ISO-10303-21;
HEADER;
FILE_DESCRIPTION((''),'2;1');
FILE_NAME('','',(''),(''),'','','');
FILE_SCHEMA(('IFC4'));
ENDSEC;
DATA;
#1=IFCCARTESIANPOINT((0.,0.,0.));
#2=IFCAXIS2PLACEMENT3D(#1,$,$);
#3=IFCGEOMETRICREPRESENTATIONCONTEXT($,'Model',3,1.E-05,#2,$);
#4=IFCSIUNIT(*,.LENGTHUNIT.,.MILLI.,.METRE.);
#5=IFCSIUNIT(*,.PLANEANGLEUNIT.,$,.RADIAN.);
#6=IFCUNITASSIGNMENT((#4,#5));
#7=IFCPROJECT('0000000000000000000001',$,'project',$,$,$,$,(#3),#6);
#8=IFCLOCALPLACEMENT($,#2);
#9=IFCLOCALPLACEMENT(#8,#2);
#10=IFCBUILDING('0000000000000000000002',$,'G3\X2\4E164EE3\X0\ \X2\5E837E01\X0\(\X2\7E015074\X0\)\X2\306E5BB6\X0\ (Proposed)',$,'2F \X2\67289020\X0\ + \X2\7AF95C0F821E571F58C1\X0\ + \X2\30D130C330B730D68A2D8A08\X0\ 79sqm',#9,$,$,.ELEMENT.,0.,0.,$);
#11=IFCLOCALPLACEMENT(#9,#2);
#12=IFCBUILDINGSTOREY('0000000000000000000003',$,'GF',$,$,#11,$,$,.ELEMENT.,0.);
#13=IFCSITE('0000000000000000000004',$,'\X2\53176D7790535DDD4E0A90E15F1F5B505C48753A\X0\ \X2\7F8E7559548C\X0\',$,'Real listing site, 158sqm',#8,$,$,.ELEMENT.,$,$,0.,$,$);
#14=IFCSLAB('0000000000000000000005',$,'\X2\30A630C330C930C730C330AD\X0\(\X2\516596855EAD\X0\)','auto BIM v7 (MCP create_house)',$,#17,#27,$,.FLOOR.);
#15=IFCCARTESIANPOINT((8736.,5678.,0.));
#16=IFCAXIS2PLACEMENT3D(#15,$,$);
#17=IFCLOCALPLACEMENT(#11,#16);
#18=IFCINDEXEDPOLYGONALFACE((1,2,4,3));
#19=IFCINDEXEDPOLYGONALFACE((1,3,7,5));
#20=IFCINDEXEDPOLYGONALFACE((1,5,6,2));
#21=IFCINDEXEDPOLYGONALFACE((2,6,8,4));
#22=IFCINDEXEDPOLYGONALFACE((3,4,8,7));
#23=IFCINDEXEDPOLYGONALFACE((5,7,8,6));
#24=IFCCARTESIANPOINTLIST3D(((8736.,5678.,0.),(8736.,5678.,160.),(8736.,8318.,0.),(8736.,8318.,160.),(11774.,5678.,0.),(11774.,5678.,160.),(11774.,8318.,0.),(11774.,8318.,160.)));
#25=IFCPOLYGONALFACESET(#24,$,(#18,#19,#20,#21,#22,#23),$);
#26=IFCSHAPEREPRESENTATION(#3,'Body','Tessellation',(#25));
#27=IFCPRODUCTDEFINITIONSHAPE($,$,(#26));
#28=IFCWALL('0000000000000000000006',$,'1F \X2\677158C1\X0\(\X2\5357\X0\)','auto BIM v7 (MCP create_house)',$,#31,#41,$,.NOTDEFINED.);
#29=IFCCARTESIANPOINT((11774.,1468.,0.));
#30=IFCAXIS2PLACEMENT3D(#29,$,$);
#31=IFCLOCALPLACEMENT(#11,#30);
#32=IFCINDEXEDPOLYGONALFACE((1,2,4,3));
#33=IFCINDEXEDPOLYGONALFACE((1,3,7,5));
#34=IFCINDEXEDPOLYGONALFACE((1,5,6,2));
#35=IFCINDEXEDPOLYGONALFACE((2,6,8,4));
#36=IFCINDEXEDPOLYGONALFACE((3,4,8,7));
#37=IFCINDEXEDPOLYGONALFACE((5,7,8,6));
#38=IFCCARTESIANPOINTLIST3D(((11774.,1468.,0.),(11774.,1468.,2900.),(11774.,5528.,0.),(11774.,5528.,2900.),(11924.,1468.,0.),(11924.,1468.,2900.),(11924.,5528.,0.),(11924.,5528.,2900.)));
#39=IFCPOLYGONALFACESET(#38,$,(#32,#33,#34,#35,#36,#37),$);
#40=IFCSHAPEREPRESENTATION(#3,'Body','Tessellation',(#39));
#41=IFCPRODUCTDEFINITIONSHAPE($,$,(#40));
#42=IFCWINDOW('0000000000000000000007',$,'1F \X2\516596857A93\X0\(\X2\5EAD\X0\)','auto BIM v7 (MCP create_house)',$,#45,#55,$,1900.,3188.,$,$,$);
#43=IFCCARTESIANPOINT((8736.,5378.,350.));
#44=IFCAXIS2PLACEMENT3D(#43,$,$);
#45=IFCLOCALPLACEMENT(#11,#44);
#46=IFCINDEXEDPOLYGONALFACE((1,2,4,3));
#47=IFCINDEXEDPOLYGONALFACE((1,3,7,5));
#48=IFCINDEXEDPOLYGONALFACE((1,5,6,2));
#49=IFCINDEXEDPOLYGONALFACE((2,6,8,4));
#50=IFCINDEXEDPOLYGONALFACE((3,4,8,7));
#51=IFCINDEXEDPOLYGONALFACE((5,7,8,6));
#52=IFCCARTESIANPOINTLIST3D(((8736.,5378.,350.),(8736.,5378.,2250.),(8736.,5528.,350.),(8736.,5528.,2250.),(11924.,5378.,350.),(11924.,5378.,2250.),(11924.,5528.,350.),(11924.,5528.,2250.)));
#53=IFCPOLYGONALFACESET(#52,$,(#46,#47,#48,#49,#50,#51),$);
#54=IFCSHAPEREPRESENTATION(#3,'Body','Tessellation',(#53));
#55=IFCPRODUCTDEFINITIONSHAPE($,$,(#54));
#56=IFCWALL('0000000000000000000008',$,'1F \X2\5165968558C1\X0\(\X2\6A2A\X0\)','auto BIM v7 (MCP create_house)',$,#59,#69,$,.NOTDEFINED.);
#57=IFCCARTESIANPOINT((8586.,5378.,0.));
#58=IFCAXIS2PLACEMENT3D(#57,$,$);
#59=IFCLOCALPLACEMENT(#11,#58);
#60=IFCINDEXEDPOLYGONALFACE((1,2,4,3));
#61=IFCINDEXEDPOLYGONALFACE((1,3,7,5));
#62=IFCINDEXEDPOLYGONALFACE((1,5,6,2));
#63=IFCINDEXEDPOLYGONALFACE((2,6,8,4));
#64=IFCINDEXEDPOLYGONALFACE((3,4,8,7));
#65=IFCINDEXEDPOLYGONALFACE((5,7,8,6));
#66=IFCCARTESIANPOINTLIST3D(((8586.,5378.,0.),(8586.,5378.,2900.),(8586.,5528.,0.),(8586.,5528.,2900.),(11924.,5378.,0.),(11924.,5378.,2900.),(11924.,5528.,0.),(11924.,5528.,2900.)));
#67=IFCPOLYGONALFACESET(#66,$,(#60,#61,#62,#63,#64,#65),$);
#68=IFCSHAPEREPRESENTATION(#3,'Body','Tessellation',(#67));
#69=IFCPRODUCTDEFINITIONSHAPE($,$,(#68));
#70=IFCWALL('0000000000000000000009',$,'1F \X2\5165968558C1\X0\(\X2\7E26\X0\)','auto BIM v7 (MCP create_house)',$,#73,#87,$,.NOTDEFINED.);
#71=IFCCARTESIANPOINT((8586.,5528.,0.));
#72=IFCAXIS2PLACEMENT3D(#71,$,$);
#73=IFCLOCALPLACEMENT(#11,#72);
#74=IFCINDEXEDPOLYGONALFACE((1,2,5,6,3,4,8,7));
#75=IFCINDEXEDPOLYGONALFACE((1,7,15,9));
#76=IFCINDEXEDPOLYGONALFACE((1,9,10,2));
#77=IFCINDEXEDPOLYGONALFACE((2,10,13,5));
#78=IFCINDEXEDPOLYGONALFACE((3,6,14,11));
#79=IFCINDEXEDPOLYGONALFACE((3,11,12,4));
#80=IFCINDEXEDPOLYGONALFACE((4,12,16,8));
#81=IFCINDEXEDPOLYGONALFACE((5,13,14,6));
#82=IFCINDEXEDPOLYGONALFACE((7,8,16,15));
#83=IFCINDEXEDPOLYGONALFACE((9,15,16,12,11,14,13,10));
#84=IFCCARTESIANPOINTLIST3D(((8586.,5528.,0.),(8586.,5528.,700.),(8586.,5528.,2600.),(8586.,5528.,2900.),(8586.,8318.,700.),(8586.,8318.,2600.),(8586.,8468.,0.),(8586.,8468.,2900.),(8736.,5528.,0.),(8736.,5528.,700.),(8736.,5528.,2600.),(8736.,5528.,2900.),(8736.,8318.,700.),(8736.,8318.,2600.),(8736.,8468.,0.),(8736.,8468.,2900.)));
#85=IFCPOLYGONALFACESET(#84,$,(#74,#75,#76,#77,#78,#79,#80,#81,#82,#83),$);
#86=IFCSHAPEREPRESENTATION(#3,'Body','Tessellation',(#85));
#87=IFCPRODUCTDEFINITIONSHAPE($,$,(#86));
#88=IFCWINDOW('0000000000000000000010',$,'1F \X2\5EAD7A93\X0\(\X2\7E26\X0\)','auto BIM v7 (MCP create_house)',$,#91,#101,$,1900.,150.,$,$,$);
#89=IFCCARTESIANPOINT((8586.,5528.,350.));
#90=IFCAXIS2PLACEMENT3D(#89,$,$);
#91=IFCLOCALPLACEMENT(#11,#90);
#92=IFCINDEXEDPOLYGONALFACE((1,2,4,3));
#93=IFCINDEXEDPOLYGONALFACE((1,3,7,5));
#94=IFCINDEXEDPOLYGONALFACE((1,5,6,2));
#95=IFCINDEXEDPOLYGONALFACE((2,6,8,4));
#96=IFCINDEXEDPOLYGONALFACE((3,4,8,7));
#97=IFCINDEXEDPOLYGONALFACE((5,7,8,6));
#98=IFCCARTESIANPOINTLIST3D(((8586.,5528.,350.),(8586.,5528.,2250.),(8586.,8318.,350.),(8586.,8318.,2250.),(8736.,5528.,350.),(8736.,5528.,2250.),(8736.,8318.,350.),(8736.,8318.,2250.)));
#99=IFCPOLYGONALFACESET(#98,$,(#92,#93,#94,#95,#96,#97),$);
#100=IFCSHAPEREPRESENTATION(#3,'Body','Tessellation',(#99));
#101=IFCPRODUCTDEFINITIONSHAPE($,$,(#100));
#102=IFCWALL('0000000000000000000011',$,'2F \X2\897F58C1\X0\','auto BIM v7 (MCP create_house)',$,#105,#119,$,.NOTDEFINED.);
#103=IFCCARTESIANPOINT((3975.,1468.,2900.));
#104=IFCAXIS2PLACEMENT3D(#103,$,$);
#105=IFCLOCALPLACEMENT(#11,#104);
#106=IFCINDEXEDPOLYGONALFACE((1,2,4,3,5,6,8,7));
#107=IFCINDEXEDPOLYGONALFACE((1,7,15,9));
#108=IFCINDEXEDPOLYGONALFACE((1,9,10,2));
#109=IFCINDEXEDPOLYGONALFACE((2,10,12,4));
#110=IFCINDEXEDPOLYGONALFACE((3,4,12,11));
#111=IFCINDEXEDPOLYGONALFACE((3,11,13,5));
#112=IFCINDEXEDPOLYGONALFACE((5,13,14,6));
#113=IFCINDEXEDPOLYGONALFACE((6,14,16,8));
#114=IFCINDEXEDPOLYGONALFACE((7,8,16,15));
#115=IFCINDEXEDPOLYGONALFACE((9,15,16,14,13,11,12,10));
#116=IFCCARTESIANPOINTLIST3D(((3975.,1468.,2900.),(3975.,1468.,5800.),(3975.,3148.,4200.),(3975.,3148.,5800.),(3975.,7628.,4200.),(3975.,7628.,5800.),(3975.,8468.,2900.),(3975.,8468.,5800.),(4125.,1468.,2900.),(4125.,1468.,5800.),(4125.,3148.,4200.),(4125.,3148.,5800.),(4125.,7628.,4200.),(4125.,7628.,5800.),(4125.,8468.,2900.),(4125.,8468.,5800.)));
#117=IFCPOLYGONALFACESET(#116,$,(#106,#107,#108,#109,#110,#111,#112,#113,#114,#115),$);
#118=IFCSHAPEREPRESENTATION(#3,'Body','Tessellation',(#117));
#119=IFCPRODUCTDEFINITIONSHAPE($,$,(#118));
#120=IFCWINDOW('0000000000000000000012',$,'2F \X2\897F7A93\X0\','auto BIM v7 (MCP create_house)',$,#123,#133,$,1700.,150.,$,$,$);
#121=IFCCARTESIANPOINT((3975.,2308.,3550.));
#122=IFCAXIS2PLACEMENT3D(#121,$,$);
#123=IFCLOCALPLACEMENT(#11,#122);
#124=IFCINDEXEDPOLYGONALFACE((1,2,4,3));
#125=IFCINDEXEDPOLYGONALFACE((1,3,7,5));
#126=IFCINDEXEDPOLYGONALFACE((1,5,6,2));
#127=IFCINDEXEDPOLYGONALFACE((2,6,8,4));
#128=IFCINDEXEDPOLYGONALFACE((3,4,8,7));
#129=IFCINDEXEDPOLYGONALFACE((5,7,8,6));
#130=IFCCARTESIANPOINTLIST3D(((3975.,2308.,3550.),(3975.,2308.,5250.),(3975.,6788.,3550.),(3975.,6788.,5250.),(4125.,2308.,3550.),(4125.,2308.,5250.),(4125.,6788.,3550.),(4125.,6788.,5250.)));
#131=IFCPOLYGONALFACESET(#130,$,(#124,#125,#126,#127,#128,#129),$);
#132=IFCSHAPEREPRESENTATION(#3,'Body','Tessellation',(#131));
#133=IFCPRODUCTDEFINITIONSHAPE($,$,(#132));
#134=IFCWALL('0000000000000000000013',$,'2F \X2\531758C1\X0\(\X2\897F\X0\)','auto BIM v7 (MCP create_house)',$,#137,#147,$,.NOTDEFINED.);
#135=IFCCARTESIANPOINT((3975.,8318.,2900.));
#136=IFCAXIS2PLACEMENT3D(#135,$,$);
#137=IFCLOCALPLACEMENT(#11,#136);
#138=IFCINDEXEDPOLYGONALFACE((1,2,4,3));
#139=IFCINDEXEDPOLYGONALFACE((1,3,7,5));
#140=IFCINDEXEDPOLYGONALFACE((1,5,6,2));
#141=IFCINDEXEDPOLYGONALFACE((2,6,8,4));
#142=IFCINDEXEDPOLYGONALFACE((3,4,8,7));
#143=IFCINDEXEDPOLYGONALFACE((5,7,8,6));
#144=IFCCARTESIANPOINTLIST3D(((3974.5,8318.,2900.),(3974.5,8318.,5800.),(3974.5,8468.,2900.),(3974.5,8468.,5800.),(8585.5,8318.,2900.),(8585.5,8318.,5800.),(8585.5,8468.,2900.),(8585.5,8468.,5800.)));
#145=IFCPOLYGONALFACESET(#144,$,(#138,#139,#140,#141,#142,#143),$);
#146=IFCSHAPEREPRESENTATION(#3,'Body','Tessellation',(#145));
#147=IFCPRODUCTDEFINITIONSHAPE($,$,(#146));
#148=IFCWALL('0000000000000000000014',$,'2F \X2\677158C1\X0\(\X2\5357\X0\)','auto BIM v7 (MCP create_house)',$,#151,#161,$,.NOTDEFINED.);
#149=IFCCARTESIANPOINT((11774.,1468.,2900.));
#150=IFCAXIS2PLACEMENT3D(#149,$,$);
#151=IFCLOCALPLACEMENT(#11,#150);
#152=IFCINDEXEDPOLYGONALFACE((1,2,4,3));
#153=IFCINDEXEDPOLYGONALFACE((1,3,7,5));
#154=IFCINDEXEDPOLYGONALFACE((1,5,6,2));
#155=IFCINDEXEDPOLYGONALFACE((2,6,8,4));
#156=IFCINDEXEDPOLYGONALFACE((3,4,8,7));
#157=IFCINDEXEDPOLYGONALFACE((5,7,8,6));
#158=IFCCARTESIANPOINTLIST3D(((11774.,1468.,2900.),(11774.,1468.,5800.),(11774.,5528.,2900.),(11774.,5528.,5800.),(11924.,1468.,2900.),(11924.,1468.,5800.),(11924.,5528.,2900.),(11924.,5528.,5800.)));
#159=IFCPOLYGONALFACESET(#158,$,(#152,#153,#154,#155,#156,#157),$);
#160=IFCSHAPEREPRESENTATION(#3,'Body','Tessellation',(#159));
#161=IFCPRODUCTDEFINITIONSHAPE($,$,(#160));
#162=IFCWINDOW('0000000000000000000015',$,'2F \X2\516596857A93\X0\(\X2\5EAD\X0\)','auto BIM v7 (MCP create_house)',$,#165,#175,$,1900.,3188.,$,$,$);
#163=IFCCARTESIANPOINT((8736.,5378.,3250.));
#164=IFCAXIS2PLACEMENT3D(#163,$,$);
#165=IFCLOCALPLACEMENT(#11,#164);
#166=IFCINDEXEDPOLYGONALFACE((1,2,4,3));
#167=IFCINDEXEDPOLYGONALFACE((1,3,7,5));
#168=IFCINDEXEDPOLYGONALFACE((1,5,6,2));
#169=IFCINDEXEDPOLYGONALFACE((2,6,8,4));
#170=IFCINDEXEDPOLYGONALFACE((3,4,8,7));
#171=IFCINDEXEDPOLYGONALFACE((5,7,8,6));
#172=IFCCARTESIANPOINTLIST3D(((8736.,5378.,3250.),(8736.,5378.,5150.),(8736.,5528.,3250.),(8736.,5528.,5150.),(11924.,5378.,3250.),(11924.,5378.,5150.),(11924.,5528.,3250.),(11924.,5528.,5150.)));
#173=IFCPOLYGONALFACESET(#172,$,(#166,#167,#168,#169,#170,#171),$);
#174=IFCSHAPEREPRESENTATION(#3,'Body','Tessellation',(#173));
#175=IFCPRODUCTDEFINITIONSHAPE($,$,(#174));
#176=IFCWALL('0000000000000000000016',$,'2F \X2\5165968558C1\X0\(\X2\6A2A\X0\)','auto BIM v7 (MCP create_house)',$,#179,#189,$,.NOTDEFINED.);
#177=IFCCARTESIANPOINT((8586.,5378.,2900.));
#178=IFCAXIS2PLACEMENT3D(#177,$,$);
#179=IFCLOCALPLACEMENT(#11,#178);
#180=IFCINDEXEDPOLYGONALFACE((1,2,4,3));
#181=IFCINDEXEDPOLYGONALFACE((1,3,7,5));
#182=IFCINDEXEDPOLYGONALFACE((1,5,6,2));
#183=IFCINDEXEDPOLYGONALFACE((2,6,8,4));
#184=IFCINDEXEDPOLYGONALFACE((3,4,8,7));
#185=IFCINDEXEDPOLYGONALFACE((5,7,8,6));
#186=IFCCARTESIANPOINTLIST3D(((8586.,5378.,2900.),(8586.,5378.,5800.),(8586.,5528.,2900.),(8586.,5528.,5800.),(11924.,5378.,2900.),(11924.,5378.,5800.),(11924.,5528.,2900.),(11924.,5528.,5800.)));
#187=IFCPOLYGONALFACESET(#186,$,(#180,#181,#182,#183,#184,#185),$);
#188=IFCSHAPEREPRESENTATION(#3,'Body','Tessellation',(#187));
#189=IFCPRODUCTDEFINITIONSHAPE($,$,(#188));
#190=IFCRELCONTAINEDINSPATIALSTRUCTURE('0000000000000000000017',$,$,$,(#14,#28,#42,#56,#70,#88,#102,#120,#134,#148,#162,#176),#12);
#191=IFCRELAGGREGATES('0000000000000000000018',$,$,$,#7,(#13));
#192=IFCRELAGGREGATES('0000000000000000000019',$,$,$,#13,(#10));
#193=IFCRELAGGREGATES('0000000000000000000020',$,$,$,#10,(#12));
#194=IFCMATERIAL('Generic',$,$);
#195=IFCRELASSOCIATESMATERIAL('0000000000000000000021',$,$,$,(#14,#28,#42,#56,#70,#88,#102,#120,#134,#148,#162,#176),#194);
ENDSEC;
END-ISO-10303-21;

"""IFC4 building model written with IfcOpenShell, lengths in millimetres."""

from ifc_helpers import new_model, si_unit, frame, frame_2d, origin, place, context, project, spatial, rectangle, extrude, material, element, fill, save


model = new_model("IFC4")

# Units and contexts
model_context = context("Model", 3, precision=1e-05, world=origin())
ifc_project = project(units=[si_unit("LENGTHUNIT", "METRE", prefix="MILLI"), si_unit("PLANEANGLEUNIT", "RADIAN")], contexts=[model_context])

# Site, building, storey
site_placement = place(None, origin())
site = spatial("IfcSite", under=ifc_project, at=site_placement, Name="北海道川上郡弟子屈町 美留和", ObjectType="Real listing site, 158sqm", CompositionType="ELEMENT", RefElevation=0.0)
building_placement = place(site_placement, origin())
building = spatial("IfcBuilding", under=site, at=building_placement, Name="G3世代 広縁(縁側)の家 (Proposed)", ObjectType="2F 木造 + 竹小舞土壁 + パッシブ設計 79sqm", CompositionType="ELEMENT", ElevationOfRefHeight=0.0, ElevationOfTerrain=0.0)
storey_placement = place(building_placement, origin())
storey = spatial("IfcBuildingStorey", under=building, at=storey_placement, Name="GF", CompositionType="ELEMENT", Elevation=0.0)

# Slab
ifc_material = material(Name="Generic")
slab_placement = place(storey_placement, frame((8736.0, 5678.0, 0.0)))
element("IfcSlab", 1, at=slab_placement, inside=storey, material=ifc_material, Name="ウッドデッキ(入隅庭)", Description="auto BIM v7 (MCP create_house)", PredefinedType="FLOOR", context=model_context, shape_type="SweptSolid", body=[
    extrude(rectangle(XDim=3038.0, YDim=2640.0, at=frame_2d((1519.0, 1320.0))), frame((8736.0, 5678.0, 0.0)), (0.0, 0.0, 1.0), 160.0),
])

# Wall, opening, window
wall_1_placement = place(storey_placement, frame((11774.0, 1468.0, 0.0)))
wall_1 = element("IfcWall", 2, at=wall_1_placement, inside=storey, material=ifc_material, Name="1F 東壁(南)", Description="auto BIM v7 (MCP create_house)", PredefinedType="NOTDEFINED", context=model_context, shape_type="SweptSolid", body=[
    extrude(rectangle(XDim=150.0, YDim=4060.0, at=frame_2d((75.0, 2030.0))), frame((11774.0, 1468.0, 0.0)), (0.0, 0.0, 1.0), 2900.0),
])
opening_1_placement = place(storey_placement, frame((8736.0, 5378.0, 350.0)))
opening_1 = element("IfcOpeningElement", 3, at=opening_1_placement, cuts=wall_1, PredefinedType="NOTDEFINED", context=model_context, shape_type="SweptSolid", body=[
    extrude(rectangle(XDim=3188.0, YDim=150.0, at=frame_2d((1594.0, 75.0))), frame((8736.0, 5378.0, 350.0)), (0.0, 0.0, 1.0), 1900.0),
])
window_1_placement = place(storey_placement, frame((8736.0, 5378.0, 350.0)))
window_1 = element("IfcWindow", 4, at=window_1_placement, inside=storey, material=ifc_material, Name="1F 入隅窓(庭)", Description="auto BIM v7 (MCP create_house)", OverallHeight=1900.0, OverallWidth=3188.0, context=model_context, shape_type="SweptSolid", body=[
    extrude(rectangle(XDim=3188.0, YDim=150.0, at=frame_2d((1594.0, 75.0))), frame((8736.0, 5378.0, 350.0)), (0.0, 0.0, 1.0), 1900.0),
])
fill(opening_1, window_1)

# Wall
wall_2_placement = place(storey_placement, frame((8586.0, 5378.0, 0.0)))
element("IfcWall", 5, at=wall_2_placement, inside=storey, material=ifc_material, Name="1F 入隅壁(横)", Description="auto BIM v7 (MCP create_house)", PredefinedType="NOTDEFINED", context=model_context, shape_type="SweptSolid", body=[
    extrude(rectangle(XDim=3338.0, YDim=150.0, at=frame_2d((1669.0, 75.0))), frame((8586.0, 5378.0, 0.0)), (0.0, 0.0, 1.0), 2900.0),
])

# Wall, opening, window
wall_3_placement = place(storey_placement, frame((8586.0, 5528.0, 0.0)))
wall_3 = element("IfcWall", 6, at=wall_3_placement, inside=storey, material=ifc_material, Name="1F 入隅壁(縦)", Description="auto BIM v7 (MCP create_house)", PredefinedType="NOTDEFINED", context=model_context, shape_type="SweptSolid", body=[
    extrude(rectangle(XDim=150.0, YDim=2940.0, at=frame_2d((75.0, 1470.0))), frame((8586.0, 5528.0, 0.0)), (0.0, 0.0, 1.0), 2900.0),
])
opening_2_placement = place(storey_placement, frame((8586.0, 5528.0, 350.0)))
opening_2 = element("IfcOpeningElement", 7, at=opening_2_placement, cuts=wall_3, PredefinedType="NOTDEFINED", context=model_context, shape_type="SweptSolid", body=[
    extrude(rectangle(XDim=150.0, YDim=2790.0, at=frame_2d((75.0, 1395.0))), frame((8586.0, 5528.0, 350.0)), (0.0, 0.0, 1.0), 1900.0),
])
window_2_placement = place(storey_placement, frame((8586.0, 5528.0, 350.0)))
window_2 = element("IfcWindow", 8, at=window_2_placement, inside=storey, material=ifc_material, Name="1F 庭窓(縦)", Description="auto BIM v7 (MCP create_house)", OverallHeight=1900.0, OverallWidth=150.0, context=model_context, shape_type="SweptSolid", body=[
    extrude(rectangle(XDim=150.0, YDim=2790.0, at=frame_2d((75.0, 1395.0))), frame((8586.0, 5528.0, 350.0)), (0.0, 0.0, 1.0), 1900.0),
])
fill(opening_2, window_2)

# Wall, opening, window
wall_4_placement = place(storey_placement, frame((3975.0, 1468.0, 2900.0)))
wall_4 = element("IfcWall", 9, at=wall_4_placement, inside=storey, material=ifc_material, Name="2F 西壁", Description="auto BIM v7 (MCP create_house)", PredefinedType="NOTDEFINED", context=model_context, shape_type="SweptSolid", body=[
    extrude(rectangle(XDim=150.0, YDim=7000.0, at=frame_2d((75.0, 3500.0))), frame((3975.0, 1468.0, 2900.0)), (0.0, 0.0, 1.0), 2900.0),
])
opening_3_placement = place(storey_placement, frame((3975.0, 2308.0, 3550.0)))
opening_3 = element("IfcOpeningElement", 10, at=opening_3_placement, cuts=wall_4, PredefinedType="NOTDEFINED", context=model_context, shape_type="SweptSolid", body=[
    extrude(rectangle(XDim=150.0, YDim=4480.0, at=frame_2d((75.0, 2240.0))), frame((3975.0, 2308.0, 3550.0)), (0.0, 0.0, 1.0), 1700.0),
])
window_3_placement = place(storey_placement, frame((3975.0, 2308.0, 3550.0)))
window_3 = element("IfcWindow", 11, at=window_3_placement, inside=storey, material=ifc_material, Name="2F 西窓", Description="auto BIM v7 (MCP create_house)", OverallHeight=1700.0, OverallWidth=150.0, context=model_context, shape_type="SweptSolid", body=[
    extrude(rectangle(XDim=150.0, YDim=4480.0, at=frame_2d((75.0, 2240.0))), frame((3975.0, 2308.0, 3550.0)), (0.0, 0.0, 1.0), 1700.0),
])
fill(opening_3, window_3)

# Wall
wall_5_placement = place(storey_placement, frame((3975.0, 8318.0, 2900.0)))
element("IfcWall", 12, at=wall_5_placement, inside=storey, material=ifc_material, Name="2F 北壁(西)", Description="auto BIM v7 (MCP create_house)", PredefinedType="NOTDEFINED", context=model_context, shape_type="SweptSolid", body=[
    extrude(rectangle(XDim=4611.0, YDim=150.0, at=frame_2d((2305.0, 75.0))), frame((3975.0, 8318.0, 2900.0)), (0.0, 0.0, 1.0), 2900.0),
])

# Wall, opening, window
wall_6_placement = place(storey_placement, frame((11774.0, 1468.0, 2900.0)))
wall_6 = element("IfcWall", 13, at=wall_6_placement, inside=storey, material=ifc_material, Name="2F 東壁(南)", Description="auto BIM v7 (MCP create_house)", PredefinedType="NOTDEFINED", context=model_context, shape_type="SweptSolid", body=[
    extrude(rectangle(XDim=150.0, YDim=4060.0, at=frame_2d((75.0, 2030.0))), frame((11774.0, 1468.0, 2900.0)), (0.0, 0.0, 1.0), 2900.0),
])
opening_4_placement = place(storey_placement, frame((8736.0, 5378.0, 3250.0)))
opening_4 = element("IfcOpeningElement", 14, at=opening_4_placement, cuts=wall_6, PredefinedType="NOTDEFINED", context=model_context, shape_type="SweptSolid", body=[
    extrude(rectangle(XDim=3188.0, YDim=150.0, at=frame_2d((1594.0, 75.0))), frame((8736.0, 5378.0, 3250.0)), (0.0, 0.0, 1.0), 1900.0),
])
window_4_placement = place(storey_placement, frame((8736.0, 5378.0, 3250.0)))
window_4 = element("IfcWindow", 15, at=window_4_placement, inside=storey, material=ifc_material, Name="2F 入隅窓(庭)", Description="auto BIM v7 (MCP create_house)", OverallHeight=1900.0, OverallWidth=3188.0, context=model_context, shape_type="SweptSolid", body=[
    extrude(rectangle(XDim=3188.0, YDim=150.0, at=frame_2d((1594.0, 75.0))), frame((8736.0, 5378.0, 3250.0)), (0.0, 0.0, 1.0), 1900.0),
])
fill(opening_4, window_4)

# Wall
wall_7_placement = place(storey_placement, frame((8586.0, 5378.0, 2900.0)))
element("IfcWall", 16, at=wall_7_placement, inside=storey, material=ifc_material, Name="2F 入隅壁(横)", Description="auto BIM v7 (MCP create_house)", PredefinedType="NOTDEFINED", context=model_context, shape_type="SweptSolid", body=[
    extrude(rectangle(XDim=3338.0, YDim=150.0, at=frame_2d((1669.0, 75.0))), frame((8586.0, 5378.0, 2900.0)), (0.0, 0.0, 1.0), 2900.0),
])

save(model, "model.ifc")
